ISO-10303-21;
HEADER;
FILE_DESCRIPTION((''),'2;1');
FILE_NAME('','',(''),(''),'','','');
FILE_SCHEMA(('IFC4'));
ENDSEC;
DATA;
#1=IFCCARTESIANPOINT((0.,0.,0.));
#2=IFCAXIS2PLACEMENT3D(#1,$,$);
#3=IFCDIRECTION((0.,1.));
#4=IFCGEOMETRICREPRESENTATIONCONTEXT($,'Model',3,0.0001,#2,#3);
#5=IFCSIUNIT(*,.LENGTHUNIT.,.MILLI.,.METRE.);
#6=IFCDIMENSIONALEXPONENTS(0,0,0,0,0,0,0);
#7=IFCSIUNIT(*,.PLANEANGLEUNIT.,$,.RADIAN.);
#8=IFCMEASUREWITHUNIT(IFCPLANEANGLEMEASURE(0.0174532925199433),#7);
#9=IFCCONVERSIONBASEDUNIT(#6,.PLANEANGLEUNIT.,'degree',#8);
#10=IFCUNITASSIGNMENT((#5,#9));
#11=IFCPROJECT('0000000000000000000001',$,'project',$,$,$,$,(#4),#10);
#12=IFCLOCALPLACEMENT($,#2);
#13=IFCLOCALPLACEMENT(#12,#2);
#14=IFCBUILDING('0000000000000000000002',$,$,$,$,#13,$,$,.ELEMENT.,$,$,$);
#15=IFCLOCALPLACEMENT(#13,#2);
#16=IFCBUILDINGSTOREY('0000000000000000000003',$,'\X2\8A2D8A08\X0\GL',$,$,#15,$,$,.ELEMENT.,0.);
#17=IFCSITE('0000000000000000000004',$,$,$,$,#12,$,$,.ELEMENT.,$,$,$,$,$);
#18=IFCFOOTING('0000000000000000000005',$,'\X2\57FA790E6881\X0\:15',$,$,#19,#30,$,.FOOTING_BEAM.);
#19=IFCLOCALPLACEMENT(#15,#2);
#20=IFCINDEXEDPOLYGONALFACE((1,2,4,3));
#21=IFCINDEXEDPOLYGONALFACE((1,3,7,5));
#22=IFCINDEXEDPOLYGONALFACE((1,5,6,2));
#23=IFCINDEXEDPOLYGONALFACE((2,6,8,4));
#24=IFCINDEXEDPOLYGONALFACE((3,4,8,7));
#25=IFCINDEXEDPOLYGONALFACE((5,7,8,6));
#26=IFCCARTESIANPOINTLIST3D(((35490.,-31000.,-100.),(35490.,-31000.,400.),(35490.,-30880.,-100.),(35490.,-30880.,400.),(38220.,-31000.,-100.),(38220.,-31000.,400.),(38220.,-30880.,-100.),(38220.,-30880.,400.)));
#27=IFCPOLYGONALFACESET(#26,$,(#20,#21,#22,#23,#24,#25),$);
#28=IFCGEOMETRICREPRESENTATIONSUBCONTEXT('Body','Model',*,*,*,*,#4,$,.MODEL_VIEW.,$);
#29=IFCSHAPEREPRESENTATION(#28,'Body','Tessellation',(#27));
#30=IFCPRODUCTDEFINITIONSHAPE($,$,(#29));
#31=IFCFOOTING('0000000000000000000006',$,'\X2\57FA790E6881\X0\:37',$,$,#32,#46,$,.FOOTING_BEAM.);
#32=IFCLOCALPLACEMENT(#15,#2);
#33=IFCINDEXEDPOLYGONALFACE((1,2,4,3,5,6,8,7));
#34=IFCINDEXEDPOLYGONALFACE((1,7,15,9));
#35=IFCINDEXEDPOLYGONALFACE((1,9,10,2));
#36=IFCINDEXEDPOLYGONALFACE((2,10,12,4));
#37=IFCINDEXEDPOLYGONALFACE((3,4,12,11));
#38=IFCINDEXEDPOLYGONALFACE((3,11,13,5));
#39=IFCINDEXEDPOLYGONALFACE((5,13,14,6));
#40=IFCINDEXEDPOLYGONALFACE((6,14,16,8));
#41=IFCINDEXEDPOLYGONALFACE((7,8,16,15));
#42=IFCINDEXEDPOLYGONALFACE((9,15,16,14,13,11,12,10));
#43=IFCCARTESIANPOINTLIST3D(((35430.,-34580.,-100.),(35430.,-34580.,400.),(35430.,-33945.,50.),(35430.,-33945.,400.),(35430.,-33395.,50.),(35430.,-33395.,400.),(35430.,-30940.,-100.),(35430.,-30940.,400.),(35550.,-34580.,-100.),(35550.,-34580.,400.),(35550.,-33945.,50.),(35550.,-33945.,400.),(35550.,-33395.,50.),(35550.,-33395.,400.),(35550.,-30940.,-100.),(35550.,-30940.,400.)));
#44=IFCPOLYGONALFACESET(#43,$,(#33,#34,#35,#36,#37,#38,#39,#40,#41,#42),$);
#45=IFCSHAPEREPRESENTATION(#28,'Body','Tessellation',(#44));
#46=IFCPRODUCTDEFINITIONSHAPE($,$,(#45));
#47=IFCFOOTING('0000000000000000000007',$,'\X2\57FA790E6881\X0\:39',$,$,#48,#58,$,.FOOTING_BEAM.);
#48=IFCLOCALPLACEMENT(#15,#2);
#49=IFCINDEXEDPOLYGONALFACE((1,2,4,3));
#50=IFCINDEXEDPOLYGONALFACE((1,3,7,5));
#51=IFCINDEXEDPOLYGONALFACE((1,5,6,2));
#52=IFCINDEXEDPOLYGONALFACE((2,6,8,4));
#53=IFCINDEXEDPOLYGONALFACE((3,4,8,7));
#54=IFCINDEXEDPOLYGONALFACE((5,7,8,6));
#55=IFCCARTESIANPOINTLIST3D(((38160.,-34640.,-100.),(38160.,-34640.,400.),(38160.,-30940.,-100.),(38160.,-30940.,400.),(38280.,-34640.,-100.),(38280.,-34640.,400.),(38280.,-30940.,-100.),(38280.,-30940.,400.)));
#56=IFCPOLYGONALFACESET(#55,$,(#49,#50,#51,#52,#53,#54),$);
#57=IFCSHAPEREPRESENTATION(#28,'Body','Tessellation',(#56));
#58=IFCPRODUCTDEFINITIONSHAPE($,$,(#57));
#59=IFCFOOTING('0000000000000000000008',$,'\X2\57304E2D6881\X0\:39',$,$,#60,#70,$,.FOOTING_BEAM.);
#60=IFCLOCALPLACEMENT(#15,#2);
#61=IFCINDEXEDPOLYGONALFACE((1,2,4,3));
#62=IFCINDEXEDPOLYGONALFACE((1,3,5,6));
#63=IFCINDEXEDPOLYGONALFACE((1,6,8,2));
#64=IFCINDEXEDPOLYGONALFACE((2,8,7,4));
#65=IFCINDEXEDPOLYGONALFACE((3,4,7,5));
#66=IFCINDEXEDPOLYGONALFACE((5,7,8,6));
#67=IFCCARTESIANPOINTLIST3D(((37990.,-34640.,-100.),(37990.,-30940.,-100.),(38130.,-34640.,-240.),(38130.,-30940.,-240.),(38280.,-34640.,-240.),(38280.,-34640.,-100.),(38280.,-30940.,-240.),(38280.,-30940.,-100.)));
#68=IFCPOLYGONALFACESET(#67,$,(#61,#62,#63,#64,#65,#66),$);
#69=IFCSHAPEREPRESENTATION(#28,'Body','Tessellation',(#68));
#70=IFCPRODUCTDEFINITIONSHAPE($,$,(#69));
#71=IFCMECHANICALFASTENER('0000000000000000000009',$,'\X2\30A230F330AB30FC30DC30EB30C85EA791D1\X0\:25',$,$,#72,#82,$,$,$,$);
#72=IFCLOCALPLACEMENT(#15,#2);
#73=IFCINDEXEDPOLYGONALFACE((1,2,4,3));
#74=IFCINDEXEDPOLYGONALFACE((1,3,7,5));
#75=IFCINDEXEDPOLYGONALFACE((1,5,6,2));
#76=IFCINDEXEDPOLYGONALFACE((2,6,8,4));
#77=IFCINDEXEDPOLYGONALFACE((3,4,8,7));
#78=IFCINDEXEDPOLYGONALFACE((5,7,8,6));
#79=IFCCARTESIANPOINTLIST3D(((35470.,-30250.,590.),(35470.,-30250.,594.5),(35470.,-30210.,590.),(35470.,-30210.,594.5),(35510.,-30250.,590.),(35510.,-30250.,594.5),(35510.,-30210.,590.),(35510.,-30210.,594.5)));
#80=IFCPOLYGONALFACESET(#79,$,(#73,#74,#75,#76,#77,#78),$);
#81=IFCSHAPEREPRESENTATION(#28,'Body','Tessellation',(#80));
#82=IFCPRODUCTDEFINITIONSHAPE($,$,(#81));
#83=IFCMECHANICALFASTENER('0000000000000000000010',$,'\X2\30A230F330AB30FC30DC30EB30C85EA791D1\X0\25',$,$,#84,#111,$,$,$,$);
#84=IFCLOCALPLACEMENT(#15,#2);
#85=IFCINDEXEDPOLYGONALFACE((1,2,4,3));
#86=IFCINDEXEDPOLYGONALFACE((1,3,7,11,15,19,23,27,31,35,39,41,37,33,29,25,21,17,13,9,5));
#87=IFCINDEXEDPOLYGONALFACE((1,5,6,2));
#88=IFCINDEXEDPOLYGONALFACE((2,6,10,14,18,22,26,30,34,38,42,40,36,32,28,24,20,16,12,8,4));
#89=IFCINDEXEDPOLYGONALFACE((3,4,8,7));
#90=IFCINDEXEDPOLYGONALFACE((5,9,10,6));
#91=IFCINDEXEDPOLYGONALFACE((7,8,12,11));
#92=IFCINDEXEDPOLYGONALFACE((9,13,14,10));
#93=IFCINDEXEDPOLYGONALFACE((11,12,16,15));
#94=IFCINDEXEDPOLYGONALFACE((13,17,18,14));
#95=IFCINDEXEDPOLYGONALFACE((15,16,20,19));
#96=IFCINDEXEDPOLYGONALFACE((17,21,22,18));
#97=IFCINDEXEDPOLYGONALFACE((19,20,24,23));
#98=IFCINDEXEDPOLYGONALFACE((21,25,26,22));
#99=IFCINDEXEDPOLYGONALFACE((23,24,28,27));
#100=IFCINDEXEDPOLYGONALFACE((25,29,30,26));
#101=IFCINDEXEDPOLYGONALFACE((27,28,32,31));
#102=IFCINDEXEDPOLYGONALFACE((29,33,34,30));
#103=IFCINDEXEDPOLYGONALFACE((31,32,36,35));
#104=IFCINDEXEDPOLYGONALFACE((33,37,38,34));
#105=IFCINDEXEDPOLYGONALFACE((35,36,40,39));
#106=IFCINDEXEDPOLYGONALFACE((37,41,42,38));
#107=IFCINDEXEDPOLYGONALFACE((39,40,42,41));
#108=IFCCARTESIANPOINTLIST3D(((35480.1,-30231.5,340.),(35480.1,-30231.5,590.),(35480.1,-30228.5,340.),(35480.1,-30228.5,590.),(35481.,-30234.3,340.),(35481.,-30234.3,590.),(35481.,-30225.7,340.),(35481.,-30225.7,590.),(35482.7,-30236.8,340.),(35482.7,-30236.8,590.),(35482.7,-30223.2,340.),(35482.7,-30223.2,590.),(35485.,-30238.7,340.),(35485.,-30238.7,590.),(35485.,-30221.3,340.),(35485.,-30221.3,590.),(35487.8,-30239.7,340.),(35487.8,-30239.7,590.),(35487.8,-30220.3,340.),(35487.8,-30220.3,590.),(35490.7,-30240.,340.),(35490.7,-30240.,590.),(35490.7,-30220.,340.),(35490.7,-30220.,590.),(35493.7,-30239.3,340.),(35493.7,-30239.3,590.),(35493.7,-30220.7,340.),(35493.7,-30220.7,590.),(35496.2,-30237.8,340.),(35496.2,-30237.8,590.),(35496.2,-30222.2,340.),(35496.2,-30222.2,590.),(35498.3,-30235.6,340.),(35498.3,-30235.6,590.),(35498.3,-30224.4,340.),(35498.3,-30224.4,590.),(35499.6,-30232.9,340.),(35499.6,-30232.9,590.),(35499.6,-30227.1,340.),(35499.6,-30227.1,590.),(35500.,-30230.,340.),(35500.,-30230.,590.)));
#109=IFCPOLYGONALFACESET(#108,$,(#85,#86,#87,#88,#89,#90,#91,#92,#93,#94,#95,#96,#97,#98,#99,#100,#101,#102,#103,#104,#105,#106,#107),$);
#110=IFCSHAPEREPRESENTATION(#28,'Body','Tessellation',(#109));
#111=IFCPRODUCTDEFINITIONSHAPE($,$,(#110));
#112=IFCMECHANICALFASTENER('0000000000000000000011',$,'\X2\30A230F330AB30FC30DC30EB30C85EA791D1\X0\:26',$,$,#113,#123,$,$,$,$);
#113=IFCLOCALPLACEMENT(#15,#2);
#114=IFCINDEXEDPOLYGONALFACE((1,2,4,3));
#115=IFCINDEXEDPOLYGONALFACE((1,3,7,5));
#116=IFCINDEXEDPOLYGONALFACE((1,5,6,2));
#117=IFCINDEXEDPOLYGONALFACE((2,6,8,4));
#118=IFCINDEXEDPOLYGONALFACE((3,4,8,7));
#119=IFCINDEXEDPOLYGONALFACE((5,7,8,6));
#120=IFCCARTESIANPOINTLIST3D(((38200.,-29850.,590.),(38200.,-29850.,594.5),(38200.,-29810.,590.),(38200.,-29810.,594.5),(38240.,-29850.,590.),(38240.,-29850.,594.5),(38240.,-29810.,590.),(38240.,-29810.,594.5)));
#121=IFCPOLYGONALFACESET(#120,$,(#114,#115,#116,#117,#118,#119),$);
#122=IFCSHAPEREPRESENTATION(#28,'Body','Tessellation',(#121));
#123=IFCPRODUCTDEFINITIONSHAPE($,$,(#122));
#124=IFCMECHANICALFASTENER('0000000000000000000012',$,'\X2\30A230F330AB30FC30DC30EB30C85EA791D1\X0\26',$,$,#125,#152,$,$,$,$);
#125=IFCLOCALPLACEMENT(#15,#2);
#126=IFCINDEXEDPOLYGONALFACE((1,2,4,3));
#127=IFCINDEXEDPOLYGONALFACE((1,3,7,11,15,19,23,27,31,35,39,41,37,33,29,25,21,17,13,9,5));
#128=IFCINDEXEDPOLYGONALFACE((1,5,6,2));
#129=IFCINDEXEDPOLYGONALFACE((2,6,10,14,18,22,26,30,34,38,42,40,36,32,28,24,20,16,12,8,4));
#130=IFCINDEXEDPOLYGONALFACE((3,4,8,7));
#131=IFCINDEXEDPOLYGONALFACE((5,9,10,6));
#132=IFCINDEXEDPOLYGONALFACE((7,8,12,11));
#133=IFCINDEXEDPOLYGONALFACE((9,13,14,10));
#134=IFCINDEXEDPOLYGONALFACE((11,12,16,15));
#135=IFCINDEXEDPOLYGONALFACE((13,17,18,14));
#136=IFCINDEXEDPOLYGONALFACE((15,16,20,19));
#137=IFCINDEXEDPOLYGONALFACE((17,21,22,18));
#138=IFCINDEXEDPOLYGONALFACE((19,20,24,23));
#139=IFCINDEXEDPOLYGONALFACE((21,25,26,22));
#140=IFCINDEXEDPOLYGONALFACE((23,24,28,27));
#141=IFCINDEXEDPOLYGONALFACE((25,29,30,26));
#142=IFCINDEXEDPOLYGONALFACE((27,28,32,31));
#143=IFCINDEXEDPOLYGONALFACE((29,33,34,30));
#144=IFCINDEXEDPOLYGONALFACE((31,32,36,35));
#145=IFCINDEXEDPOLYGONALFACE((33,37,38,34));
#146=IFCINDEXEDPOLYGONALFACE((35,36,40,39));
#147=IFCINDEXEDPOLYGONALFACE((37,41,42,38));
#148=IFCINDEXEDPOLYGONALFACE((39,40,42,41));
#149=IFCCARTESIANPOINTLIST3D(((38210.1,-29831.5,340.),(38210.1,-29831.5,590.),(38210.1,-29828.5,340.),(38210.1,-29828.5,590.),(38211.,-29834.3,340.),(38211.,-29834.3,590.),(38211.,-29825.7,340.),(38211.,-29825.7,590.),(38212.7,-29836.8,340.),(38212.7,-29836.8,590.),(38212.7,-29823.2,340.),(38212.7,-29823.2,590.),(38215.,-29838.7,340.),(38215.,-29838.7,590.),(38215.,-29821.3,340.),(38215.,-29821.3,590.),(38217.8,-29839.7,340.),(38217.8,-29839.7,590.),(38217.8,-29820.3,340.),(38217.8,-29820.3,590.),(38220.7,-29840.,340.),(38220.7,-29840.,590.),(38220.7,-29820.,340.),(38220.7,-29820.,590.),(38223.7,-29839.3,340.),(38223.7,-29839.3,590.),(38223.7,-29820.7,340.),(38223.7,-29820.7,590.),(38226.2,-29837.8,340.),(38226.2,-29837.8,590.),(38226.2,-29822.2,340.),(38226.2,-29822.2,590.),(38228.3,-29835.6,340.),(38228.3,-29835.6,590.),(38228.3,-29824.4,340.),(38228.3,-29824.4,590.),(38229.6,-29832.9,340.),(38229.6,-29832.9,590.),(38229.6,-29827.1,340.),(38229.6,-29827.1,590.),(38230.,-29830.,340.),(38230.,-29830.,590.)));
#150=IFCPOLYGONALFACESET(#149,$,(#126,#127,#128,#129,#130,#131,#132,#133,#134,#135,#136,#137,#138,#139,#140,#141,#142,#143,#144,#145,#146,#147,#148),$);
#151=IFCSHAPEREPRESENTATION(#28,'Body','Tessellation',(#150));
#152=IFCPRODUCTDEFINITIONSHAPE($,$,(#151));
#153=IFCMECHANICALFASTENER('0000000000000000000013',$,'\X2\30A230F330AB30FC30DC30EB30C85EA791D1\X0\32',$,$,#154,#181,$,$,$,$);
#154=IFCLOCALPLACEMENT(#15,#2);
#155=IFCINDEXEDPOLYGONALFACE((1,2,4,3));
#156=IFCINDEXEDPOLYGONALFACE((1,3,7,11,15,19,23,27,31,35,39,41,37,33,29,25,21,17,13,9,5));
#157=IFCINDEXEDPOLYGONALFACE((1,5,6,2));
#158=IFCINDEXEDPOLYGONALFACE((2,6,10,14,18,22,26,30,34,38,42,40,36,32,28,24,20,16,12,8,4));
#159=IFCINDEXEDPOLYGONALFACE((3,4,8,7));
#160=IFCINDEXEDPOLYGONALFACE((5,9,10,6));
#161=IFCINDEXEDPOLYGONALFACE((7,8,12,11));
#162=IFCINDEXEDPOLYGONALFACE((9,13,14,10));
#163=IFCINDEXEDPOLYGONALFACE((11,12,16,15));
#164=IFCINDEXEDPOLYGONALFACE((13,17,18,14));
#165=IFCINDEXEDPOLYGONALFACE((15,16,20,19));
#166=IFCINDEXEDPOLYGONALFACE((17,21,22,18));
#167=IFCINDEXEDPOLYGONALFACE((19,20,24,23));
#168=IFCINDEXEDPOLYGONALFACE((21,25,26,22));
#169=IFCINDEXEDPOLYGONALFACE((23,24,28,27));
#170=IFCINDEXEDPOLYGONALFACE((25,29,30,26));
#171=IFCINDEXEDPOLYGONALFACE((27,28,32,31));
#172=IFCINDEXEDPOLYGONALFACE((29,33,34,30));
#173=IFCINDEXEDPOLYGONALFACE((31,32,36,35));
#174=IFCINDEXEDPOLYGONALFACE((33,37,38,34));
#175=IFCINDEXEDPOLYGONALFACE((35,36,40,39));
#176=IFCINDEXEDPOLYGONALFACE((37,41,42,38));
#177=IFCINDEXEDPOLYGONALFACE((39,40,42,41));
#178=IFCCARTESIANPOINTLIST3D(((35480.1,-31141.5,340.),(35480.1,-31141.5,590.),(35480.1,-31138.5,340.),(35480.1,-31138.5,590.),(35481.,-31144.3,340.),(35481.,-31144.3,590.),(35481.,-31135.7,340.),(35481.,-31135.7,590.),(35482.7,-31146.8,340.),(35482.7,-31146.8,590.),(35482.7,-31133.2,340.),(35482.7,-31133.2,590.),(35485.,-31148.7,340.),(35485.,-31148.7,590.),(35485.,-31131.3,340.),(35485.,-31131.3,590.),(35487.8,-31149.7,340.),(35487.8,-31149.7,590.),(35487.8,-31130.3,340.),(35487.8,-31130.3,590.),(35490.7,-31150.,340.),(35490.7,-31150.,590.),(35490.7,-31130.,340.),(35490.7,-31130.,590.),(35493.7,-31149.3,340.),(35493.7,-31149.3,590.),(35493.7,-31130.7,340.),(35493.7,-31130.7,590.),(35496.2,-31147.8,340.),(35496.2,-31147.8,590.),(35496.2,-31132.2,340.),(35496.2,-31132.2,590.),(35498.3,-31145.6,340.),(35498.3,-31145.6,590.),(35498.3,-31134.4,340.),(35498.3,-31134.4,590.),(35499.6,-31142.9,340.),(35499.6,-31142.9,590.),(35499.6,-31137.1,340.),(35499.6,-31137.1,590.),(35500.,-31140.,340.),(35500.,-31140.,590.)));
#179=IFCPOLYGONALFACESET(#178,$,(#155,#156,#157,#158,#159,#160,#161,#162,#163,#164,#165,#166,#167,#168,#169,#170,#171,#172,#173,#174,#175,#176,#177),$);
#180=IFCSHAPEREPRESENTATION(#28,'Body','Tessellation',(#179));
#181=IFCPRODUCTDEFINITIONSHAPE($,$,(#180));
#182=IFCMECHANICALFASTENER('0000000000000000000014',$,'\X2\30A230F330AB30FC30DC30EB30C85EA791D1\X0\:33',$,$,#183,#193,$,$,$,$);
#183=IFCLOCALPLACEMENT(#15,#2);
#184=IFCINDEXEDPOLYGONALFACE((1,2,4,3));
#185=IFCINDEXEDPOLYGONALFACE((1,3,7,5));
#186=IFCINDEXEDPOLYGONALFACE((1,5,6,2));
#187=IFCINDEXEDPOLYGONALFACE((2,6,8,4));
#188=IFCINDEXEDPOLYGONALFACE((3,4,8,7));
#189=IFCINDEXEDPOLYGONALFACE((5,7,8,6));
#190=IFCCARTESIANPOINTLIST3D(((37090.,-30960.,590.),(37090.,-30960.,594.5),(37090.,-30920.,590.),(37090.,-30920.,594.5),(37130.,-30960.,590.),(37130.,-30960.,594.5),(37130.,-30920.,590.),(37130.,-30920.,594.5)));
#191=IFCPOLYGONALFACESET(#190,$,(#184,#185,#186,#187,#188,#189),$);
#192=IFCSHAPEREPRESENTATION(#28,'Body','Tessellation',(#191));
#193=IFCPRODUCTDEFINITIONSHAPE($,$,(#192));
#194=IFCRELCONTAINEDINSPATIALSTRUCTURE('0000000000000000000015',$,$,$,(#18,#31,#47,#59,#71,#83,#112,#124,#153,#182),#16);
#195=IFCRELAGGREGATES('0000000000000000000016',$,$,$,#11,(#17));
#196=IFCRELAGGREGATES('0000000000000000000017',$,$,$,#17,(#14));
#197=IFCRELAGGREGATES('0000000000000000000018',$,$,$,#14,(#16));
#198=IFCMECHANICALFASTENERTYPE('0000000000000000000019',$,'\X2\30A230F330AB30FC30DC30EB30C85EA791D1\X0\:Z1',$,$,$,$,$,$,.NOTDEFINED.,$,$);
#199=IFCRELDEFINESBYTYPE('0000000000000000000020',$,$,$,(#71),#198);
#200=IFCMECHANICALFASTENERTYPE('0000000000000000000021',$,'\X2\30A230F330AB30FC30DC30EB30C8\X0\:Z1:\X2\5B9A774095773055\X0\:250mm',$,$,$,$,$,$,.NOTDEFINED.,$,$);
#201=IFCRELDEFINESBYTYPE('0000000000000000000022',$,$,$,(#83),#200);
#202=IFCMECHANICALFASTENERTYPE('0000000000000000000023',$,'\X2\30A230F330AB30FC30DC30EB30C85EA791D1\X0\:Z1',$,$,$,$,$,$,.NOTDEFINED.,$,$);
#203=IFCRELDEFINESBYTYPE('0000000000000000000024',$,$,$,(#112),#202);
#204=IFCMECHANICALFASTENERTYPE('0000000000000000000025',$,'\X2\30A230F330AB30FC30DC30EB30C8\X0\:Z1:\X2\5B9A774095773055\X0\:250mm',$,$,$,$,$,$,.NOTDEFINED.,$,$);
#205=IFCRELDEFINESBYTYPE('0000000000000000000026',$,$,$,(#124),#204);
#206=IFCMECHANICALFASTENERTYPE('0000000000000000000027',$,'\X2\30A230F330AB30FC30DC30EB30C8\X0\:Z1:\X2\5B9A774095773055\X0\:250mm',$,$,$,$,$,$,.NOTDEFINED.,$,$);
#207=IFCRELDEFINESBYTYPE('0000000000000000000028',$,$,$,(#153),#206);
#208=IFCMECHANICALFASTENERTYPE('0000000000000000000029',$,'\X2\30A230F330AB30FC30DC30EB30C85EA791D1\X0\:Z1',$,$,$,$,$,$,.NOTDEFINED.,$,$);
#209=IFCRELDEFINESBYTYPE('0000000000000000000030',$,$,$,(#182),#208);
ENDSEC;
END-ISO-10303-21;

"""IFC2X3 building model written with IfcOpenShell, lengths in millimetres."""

from ifc_helpers import new_model, entity, si_unit, converted_unit, direction, frame, origin, origin_with_axes, origin_2d, place, context, subcontext, project, spatial, polyline, rectangle, circle, outline, extrude, boolean, type_object, element, save


model = new_model("IFC2X3")

# Units and contexts
model_context = context("Model", 3, precision=0.0001, world=origin(), true_north=direction((0.0, 1.0)))
body_context = subcontext(model_context, "Body", "Model", "MODEL_VIEW")
ifc_project = project(units=[si_unit("LENGTHUNIT", "METRE", prefix="MILLI"), converted_unit("PLANEANGLEUNIT", "degree", entity("IfcPlaneAngleMeasure", 0.0174532925199433), si_unit("PLANEANGLEUNIT", "RADIAN"), dimensions=[0, 0, 0, 0, 0, 0, 0])], contexts=[model_context])

# Site, building, storey
site_placement = place(None, origin())
site = spatial("IfcSite", under=ifc_project, at=site_placement, CompositionType="ELEMENT")
building_placement = place(site_placement, origin())
building = spatial("IfcBuilding", under=site, at=building_placement, CompositionType="ELEMENT")
storey_placement = place(building_placement, origin())
storey = spatial("IfcBuildingStorey", under=building, at=storey_placement, Name="設計GL", CompositionType="ELEMENT", Elevation=0.0)

# Footings
footing_1_placement = place(storey_placement, frame((35490.0, -30940.0, 150.0), z_axis=(1.0, 0.0, 0.0), x_axis=(0.0, 1.0, 0.0)))
element("IfcFooting", 1, at=footing_1_placement, inside=storey, Name="基礎梁:15", PredefinedType="FOOTING_BEAM", context=body_context, shape_type="SolidModel", body=[
    extrude(rectangle(XDim=120.0, YDim=500.0, at=origin_2d()), origin_with_axes(), (0.0, 0.0, 1.0), 2730.0),
])
footing_2_placement = place(storey_placement, frame((35490.0, -30940.0, 150.0), z_axis=(0.0, -1.0, 0.0), x_axis=(1.0, 0.0, 0.0)))
element("IfcFooting", 2, at=footing_2_placement, inside=storey, Name="基礎梁:37", PredefinedType="FOOTING_BEAM", context=body_context, shape_type="CSG", body=[
    boolean("DIFFERENCE", extrude(rectangle(XDim=120.0, YDim=500.0, at=origin_2d()), origin_with_axes(), (0.0, 0.0, 1.0), 3640.0), extrude(rectangle(XDim=124.0, YDim=350.0, at=origin_2d()), frame((0.0, 75.0, 2455.0), z_axis=(0.0, 0.0, 1.0), x_axis=(1.0, 0.0, 0.0)), (0.0, 0.0, 1.0), 550.0)),
])
footing_3_placement = place(storey_placement, frame((38220.0, -30940.0, 150.0), z_axis=(0.0, -1.0, 0.0), x_axis=(1.0, 0.0, 0.0)))
element("IfcFooting", 3, at=footing_3_placement, inside=storey, Name="基礎梁:39", PredefinedType="FOOTING_BEAM", context=body_context, shape_type="SolidModel", body=[
    extrude(rectangle(XDim=120.0, YDim=500.0, at=origin_2d()), origin_with_axes(), (0.0, 0.0, 1.0), 3700.0),
])
footing_4_placement = place(storey_placement, frame((38280.0, -30940.0, -240.0), z_axis=(0.0, -1.0, 0.0), x_axis=(1.0, 0.0, 0.0)))
element("IfcFooting", 4, at=footing_4_placement, inside=storey, Name="地中梁:39", PredefinedType="FOOTING_BEAM", context=body_context, shape_type="SweptSolid", body=[
    extrude(outline(polyline([(0.0, 0.0, 0.0), (-150.0, 0.0, 0.0), (-290.0, 140.0, 0.0), (0.0, 140.0, 0.0), (0.0, 0.0, 0.0)])), origin_with_axes(), (0.0, 0.0, 1.0), 3700.0),
])

# Mechanical fasteners
mechanical_fastener_type_1 = type_object("IfcMechanicalFastenerType", Name="アンカーボルト座金:Z1")
mechanical_fastener_1_placement = place(storey_placement, frame((35490.0, -30230.0, 590.0)))
element("IfcMechanicalFastener", 5, at=mechanical_fastener_1_placement, inside=storey, type_object=mechanical_fastener_type_1, Name="アンカーボルト座金:25", context=body_context, shape_type="SweptSolid", body=[
    extrude(rectangle(XDim=40.0, YDim=40.0, at=origin_2d()), origin_with_axes(), (0.0, 0.0, 1.0), 4.5),
])
mechanical_fastener_type_2 = type_object("IfcMechanicalFastenerType", Name="アンカーボルト:Z1:定着長さ:250mm")
mechanical_fastener_2_placement = place(storey_placement, frame((35490.0, -30230.0, 340.0)))
element("IfcMechanicalFastener", 6, at=mechanical_fastener_2_placement, inside=storey, type_object=mechanical_fastener_type_2, Name="アンカーボルト座金25", context=body_context, shape_type="SweptSolid", body=[
    extrude(circle(Radius=10.0, at=origin_2d()), origin_with_axes(), (0.0, 0.0, 1.0), 250.0),
])
mechanical_fastener_type_3 = type_object("IfcMechanicalFastenerType", Name="アンカーボルト座金:Z1")
mechanical_fastener_3_placement = place(storey_placement, frame((38220.0, -29830.0, 590.0)))
element("IfcMechanicalFastener", 7, at=mechanical_fastener_3_placement, inside=storey, type_object=mechanical_fastener_type_3, Name="アンカーボルト座金:26", context=body_context, shape_type="SweptSolid", body=[
    extrude(rectangle(XDim=40.0, YDim=40.0, at=origin_2d()), origin_with_axes(), (0.0, 0.0, 1.0), 4.5),
])
mechanical_fastener_type_4 = type_object("IfcMechanicalFastenerType", Name="アンカーボルト:Z1:定着長さ:250mm")
mechanical_fastener_4_placement = place(storey_placement, frame((38220.0, -29830.0, 340.0)))
element("IfcMechanicalFastener", 8, at=mechanical_fastener_4_placement, inside=storey, type_object=mechanical_fastener_type_4, Name="アンカーボルト座金26", context=body_context, shape_type="SweptSolid", body=[
    extrude(circle(Radius=10.0, at=origin_2d()), origin_with_axes(), (0.0, 0.0, 1.0), 250.0),
])
mechanical_fastener_type_5 = type_object("IfcMechanicalFastenerType", Name="アンカーボルト:Z1:定着長さ:250mm")
mechanical_fastener_5_placement = place(storey_placement, frame((35490.0, -31140.0, 340.0)))
element("IfcMechanicalFastener", 9, at=mechanical_fastener_5_placement, inside=storey, type_object=mechanical_fastener_type_5, Name="アンカーボルト座金32", context=body_context, shape_type="SweptSolid", body=[
    extrude(circle(Radius=10.0, at=origin_2d()), origin_with_axes(), (0.0, 0.0, 1.0), 250.0),
])
mechanical_fastener_type_6 = type_object("IfcMechanicalFastenerType", Name="アンカーボルト座金:Z1")
mechanical_fastener_6_placement = place(storey_placement, frame((37110.0, -30940.0, 590.0)))
element("IfcMechanicalFastener", 10, at=mechanical_fastener_6_placement, inside=storey, type_object=mechanical_fastener_type_6, Name="アンカーボルト座金:33", context=body_context, shape_type="SweptSolid", body=[
    extrude(rectangle(XDim=40.0, YDim=40.0, at=origin_2d()), origin_with_axes(), (0.0, 0.0, 1.0), 4.5),
])

save(model, "model.ifc")
